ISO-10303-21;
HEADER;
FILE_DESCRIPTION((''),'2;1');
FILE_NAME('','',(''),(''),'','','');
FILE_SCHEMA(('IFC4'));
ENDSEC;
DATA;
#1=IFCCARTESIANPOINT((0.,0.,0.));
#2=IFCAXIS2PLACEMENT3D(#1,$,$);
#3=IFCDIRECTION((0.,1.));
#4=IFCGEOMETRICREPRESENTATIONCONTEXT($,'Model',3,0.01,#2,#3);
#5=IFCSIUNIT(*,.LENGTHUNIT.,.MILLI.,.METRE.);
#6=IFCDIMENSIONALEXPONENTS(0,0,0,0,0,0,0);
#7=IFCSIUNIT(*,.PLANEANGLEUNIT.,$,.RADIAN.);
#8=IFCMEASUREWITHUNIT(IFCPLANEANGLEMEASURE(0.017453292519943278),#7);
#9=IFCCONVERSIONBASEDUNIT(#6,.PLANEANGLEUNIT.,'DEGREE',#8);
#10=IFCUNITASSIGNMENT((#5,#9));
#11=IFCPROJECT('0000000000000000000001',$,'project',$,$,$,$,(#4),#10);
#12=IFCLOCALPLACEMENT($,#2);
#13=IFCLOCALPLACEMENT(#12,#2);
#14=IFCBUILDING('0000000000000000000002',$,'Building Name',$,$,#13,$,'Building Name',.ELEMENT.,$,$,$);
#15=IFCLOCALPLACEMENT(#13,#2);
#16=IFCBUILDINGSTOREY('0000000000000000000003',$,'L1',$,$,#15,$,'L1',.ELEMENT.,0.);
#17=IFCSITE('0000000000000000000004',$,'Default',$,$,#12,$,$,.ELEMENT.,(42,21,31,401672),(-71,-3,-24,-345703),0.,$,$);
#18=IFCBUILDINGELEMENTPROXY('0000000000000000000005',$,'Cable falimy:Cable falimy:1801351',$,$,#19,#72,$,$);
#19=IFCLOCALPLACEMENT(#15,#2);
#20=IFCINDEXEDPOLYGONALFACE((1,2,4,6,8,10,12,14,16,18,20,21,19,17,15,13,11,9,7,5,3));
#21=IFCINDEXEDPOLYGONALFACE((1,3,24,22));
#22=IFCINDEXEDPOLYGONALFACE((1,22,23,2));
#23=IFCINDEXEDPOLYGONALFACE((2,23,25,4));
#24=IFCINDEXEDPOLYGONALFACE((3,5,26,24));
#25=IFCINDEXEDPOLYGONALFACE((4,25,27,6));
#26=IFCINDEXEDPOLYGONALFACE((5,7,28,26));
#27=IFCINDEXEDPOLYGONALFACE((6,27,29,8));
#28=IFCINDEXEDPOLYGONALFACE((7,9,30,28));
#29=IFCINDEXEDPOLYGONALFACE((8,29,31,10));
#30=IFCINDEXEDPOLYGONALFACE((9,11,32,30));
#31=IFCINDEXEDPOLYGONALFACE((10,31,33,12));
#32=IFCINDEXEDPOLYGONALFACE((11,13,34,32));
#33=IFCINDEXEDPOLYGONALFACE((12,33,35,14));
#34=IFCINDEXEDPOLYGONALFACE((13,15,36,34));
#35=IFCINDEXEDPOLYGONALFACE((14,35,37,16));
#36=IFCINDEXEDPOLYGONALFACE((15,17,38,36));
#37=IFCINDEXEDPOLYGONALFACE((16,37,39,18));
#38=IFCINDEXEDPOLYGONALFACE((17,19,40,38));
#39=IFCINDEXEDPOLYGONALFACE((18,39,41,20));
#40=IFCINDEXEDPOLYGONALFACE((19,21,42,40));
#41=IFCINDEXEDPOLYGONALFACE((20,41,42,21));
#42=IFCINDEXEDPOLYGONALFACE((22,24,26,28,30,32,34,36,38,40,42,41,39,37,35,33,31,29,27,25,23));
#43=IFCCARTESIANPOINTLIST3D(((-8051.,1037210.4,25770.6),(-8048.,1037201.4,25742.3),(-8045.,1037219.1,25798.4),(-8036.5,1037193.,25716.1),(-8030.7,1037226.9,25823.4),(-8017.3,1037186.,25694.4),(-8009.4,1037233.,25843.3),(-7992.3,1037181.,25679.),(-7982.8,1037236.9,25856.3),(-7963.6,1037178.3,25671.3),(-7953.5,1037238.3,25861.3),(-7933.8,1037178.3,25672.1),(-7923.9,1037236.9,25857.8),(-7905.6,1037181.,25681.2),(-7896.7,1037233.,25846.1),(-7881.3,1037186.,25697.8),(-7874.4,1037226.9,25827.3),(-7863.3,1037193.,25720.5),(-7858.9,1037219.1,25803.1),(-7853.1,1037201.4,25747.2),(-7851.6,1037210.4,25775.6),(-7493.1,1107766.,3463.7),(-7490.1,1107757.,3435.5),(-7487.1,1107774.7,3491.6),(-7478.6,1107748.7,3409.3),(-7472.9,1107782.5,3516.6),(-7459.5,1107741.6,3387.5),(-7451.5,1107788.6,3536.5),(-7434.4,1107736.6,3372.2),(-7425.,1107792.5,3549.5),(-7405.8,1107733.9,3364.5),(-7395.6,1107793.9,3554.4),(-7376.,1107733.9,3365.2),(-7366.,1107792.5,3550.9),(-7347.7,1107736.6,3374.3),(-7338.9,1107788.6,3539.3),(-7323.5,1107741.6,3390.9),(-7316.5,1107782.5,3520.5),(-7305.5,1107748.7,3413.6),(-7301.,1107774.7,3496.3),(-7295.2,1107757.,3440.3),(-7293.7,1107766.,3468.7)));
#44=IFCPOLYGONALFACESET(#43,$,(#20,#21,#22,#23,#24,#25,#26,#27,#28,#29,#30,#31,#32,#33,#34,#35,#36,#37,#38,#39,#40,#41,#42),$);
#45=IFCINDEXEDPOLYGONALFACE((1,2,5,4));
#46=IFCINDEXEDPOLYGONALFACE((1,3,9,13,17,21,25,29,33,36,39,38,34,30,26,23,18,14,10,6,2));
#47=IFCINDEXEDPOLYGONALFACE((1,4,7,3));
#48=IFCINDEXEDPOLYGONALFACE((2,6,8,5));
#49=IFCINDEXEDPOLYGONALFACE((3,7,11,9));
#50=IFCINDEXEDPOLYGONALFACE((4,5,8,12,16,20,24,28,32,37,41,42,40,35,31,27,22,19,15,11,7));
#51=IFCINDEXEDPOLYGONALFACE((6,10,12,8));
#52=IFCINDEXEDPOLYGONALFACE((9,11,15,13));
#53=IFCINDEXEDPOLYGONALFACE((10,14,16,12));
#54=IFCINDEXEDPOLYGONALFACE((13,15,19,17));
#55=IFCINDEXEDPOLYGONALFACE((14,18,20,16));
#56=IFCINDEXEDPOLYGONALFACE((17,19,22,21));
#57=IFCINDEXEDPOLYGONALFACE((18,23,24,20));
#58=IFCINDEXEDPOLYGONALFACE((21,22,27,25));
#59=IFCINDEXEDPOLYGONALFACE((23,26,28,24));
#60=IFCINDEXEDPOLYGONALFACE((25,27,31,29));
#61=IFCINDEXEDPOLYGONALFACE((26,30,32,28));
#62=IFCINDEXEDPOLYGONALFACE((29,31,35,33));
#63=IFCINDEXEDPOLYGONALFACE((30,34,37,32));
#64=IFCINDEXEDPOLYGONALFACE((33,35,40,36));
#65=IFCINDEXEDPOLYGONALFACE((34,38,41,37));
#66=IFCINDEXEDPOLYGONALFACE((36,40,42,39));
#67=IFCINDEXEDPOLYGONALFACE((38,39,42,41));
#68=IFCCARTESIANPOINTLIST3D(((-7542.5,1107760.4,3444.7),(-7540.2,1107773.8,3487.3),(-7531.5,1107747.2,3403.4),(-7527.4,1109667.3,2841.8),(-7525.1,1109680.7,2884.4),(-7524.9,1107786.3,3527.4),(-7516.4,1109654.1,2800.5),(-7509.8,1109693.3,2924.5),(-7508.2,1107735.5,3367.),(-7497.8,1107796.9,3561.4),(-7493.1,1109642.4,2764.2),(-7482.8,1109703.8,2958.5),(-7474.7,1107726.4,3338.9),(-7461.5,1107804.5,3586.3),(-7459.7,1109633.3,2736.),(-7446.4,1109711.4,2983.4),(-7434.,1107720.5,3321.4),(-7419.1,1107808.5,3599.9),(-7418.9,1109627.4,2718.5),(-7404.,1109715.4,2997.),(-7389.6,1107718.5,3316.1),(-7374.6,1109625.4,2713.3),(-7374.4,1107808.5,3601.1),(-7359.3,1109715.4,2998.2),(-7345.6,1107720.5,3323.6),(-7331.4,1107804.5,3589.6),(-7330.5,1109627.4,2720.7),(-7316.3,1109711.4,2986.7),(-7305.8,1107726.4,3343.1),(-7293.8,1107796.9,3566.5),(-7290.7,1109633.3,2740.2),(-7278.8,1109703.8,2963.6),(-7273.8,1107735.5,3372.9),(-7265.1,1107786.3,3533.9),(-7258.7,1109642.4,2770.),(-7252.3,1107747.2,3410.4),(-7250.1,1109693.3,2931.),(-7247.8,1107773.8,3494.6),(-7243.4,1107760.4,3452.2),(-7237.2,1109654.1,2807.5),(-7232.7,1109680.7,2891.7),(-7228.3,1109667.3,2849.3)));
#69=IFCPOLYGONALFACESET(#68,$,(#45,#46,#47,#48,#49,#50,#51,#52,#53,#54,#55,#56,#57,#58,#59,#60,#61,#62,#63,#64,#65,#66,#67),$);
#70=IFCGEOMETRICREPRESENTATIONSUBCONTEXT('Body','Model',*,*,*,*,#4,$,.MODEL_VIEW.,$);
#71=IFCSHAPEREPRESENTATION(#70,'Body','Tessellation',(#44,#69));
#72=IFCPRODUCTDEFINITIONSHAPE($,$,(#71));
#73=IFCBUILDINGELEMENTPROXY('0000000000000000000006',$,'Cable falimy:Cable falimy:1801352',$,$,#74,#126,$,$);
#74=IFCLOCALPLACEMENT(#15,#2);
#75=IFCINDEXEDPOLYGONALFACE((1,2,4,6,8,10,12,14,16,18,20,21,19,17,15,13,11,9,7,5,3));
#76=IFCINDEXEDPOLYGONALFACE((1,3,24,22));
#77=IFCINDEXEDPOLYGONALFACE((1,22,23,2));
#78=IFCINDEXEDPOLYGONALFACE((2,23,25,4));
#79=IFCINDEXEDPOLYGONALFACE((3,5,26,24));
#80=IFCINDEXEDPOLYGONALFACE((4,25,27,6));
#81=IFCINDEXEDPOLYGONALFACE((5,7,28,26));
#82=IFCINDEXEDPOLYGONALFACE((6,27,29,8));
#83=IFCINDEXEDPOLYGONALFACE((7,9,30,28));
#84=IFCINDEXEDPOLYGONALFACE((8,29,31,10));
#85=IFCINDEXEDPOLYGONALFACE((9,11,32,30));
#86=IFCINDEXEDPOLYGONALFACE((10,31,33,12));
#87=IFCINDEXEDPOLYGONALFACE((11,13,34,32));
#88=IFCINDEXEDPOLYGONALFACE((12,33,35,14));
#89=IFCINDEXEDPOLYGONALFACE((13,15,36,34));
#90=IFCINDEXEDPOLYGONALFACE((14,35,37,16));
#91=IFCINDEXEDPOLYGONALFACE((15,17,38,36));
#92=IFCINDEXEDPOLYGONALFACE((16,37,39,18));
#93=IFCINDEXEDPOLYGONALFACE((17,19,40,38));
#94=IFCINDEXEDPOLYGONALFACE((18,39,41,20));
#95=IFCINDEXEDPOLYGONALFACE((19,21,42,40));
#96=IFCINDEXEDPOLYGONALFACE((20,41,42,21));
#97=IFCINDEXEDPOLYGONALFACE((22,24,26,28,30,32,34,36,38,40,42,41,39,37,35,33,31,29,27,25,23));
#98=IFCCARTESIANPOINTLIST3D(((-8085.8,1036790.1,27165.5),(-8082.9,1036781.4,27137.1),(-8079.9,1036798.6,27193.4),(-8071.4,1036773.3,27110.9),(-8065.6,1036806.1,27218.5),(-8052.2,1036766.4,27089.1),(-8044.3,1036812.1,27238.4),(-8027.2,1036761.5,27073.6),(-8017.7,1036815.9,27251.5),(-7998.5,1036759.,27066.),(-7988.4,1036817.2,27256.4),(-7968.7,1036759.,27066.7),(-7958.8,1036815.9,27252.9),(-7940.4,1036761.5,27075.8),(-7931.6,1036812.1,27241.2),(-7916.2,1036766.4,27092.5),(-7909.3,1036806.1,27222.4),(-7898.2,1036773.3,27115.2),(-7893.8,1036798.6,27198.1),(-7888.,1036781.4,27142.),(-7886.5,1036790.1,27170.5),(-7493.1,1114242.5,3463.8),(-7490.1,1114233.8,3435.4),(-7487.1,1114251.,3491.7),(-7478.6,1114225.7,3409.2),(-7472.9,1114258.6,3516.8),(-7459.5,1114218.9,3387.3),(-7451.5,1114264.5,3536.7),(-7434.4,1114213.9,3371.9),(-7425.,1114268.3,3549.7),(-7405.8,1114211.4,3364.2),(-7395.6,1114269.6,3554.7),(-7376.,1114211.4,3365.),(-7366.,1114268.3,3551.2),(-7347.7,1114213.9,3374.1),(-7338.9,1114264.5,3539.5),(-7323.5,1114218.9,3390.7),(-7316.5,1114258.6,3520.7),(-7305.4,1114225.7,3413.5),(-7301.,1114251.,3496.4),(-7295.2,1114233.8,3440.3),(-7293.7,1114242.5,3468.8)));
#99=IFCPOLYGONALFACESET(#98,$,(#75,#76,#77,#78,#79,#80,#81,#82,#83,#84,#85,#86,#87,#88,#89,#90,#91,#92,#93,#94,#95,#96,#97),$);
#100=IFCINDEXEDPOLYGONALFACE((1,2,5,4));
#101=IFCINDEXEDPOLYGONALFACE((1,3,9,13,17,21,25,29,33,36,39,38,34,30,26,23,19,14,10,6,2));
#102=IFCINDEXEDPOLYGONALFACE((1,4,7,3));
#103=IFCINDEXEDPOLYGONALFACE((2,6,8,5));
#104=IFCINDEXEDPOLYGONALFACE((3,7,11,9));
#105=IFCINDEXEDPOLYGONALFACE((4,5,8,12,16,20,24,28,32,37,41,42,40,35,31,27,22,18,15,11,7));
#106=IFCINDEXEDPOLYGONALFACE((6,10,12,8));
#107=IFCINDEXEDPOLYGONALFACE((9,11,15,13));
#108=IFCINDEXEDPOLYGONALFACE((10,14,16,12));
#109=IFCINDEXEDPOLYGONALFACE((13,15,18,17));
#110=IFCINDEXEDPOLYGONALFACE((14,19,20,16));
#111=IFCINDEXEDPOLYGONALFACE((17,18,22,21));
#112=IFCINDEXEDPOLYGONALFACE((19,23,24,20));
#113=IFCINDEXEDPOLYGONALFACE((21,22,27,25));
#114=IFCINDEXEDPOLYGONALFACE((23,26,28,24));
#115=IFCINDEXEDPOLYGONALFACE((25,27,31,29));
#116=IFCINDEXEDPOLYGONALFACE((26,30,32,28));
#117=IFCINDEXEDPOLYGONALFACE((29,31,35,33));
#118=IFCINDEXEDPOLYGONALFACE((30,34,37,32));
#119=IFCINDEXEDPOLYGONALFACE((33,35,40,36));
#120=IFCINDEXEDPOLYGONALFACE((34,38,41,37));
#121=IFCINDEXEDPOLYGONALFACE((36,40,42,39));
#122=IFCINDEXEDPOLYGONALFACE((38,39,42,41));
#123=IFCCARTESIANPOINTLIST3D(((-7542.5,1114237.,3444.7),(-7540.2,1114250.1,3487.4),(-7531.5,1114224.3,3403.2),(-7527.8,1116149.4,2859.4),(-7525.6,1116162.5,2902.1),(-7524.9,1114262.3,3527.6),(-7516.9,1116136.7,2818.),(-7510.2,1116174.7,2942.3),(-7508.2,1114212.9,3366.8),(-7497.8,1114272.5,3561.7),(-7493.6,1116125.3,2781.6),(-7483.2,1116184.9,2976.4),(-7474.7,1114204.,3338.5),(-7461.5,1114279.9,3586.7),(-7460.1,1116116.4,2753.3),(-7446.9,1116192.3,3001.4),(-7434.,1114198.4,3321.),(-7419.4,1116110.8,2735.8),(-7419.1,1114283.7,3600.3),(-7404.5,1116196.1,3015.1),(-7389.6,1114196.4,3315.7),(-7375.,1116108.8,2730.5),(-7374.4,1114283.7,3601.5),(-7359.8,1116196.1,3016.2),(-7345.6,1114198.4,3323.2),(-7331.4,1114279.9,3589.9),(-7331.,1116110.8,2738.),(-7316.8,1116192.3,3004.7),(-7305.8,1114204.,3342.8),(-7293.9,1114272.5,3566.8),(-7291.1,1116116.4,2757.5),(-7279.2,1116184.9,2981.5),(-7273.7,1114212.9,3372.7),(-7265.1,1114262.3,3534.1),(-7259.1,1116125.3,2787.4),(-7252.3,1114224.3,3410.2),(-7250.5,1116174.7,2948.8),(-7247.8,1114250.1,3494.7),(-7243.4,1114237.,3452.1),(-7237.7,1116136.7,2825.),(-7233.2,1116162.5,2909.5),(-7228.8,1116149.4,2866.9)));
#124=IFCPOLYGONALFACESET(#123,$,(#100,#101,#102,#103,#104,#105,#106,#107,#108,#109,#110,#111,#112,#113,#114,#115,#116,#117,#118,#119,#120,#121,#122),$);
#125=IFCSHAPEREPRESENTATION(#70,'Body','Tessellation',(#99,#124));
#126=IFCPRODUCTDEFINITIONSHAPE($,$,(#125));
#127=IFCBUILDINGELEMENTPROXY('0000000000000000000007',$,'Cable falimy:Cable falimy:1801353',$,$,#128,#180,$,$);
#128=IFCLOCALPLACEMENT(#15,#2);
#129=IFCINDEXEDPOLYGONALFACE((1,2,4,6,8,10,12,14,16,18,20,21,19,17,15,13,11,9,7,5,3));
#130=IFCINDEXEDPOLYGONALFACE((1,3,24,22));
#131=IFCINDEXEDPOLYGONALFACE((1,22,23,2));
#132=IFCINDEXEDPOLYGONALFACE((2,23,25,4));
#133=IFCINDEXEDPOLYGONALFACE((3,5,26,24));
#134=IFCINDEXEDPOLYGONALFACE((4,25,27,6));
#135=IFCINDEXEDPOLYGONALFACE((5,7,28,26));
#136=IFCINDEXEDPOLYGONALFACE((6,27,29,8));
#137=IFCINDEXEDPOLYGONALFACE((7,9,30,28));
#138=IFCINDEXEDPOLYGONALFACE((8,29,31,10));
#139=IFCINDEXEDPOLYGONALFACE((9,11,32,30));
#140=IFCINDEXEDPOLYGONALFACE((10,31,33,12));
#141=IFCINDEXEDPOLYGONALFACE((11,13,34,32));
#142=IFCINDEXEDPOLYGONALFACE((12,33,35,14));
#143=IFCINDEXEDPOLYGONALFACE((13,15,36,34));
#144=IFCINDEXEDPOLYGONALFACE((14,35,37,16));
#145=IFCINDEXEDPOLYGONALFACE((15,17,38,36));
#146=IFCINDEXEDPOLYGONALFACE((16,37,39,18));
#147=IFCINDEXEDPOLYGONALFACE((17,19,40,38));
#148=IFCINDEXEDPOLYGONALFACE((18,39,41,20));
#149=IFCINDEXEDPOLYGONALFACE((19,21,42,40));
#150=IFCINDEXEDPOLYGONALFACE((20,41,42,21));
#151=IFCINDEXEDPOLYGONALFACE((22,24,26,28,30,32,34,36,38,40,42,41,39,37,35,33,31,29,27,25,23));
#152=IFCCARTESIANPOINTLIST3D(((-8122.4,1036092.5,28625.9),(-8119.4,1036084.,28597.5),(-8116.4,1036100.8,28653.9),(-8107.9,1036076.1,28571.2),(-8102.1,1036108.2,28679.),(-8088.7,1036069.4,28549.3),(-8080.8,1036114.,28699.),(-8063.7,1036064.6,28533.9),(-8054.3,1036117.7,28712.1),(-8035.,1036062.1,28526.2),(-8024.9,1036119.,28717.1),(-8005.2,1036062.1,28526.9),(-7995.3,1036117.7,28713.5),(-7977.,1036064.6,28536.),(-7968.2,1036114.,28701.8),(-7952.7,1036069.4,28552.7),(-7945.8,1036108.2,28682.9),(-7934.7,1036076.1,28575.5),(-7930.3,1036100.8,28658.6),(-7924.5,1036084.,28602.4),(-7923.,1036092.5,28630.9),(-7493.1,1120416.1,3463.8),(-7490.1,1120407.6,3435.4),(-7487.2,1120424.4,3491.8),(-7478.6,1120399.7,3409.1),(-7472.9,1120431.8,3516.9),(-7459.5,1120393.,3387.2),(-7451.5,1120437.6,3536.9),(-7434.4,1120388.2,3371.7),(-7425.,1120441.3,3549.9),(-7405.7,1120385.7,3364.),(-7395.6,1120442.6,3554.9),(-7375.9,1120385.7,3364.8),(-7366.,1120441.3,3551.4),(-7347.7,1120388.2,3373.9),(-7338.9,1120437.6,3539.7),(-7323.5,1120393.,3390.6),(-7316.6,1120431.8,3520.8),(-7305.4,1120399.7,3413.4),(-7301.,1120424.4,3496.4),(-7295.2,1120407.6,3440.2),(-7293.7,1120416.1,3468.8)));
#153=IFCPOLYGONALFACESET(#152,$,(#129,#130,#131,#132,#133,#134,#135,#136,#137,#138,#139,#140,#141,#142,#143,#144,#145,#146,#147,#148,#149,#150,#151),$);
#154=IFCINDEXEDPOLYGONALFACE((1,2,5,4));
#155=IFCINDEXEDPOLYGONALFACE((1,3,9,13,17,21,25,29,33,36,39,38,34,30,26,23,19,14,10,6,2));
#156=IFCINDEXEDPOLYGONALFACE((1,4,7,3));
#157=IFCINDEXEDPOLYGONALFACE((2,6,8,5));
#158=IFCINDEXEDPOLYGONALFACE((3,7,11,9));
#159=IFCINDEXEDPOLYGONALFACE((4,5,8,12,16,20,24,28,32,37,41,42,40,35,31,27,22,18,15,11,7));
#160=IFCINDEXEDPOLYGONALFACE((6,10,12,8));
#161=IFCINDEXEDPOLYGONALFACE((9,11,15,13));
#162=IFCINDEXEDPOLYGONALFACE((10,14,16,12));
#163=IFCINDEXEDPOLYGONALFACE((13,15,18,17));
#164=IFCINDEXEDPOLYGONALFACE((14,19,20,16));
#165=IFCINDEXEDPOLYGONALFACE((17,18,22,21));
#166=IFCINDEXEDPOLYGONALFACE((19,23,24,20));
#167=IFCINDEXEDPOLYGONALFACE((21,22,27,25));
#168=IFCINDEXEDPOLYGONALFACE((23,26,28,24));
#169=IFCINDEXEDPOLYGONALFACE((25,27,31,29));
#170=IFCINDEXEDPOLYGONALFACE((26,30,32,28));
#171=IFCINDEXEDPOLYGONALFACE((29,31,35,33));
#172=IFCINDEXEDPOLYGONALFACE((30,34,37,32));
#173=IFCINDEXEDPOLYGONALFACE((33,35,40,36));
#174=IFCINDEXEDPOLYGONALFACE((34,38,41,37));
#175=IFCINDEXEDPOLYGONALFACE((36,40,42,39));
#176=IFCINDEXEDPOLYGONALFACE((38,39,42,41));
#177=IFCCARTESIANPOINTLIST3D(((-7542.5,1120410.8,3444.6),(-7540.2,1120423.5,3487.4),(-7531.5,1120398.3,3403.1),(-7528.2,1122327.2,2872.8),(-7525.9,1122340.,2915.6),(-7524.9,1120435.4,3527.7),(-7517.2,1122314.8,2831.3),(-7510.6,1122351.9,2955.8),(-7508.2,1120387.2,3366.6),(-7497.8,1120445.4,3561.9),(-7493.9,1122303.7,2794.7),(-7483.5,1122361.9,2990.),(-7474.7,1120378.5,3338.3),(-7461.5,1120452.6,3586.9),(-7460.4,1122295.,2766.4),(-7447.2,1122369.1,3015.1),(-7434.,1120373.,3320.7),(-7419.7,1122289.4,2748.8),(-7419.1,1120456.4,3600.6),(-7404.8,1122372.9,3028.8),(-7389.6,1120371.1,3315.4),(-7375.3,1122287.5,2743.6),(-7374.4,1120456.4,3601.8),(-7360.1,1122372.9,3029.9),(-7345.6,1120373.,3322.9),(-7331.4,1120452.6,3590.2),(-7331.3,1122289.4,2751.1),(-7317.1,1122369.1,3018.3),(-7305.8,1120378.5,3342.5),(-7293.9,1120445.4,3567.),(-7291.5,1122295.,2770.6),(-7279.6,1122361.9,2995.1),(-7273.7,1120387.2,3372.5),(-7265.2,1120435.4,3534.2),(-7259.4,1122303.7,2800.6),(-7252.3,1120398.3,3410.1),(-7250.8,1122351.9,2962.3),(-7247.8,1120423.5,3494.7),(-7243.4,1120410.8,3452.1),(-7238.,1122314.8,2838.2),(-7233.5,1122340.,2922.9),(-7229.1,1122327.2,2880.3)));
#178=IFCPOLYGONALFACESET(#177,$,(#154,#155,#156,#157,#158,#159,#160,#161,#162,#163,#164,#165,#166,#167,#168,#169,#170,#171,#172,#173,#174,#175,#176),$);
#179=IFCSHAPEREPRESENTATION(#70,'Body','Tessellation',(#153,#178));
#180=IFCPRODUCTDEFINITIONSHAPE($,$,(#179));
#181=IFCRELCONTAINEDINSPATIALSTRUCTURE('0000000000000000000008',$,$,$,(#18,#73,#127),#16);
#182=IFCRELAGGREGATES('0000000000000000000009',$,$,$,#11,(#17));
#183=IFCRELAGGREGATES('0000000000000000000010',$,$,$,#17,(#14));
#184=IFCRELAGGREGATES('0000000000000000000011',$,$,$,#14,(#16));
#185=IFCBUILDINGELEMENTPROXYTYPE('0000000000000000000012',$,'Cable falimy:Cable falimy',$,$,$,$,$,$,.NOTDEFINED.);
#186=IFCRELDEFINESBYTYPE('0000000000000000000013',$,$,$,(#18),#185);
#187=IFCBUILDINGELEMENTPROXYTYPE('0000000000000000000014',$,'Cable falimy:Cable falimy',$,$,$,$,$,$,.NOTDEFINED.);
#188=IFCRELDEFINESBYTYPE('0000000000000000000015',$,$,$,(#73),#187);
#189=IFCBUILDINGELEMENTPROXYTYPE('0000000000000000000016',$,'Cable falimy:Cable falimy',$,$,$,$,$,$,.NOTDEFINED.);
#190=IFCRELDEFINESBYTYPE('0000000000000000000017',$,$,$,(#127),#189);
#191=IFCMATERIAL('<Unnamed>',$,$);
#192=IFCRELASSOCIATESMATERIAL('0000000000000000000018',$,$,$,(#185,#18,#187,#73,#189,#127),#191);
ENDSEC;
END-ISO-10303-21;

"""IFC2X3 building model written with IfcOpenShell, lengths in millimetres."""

from ifc_helpers import new_model, entity, si_unit, converted_unit, direction, frame, frame_2d, origin, place, context, subcontext, project, spatial, circle, extrude, source, transform, mapped, material, type_object, type_shapes, element, save


model = new_model("IFC2X3")

# Units and contexts
model_context = context("Model", 3, precision=0.01, world=origin(), true_north=direction((0.0, 1.0)))
body_context = subcontext(model_context, "Body", "Model", "MODEL_VIEW")
ifc_project = project(units=[si_unit("LENGTHUNIT", "METRE", prefix="MILLI"), converted_unit("PLANEANGLEUNIT", "DEGREE", entity("IfcPlaneAngleMeasure", 0.017453292519943278), si_unit("PLANEANGLEUNIT", "RADIAN"), dimensions=[0, 0, 0, 0, 0, 0, 0])], contexts=[model_context])

# Site, building, storey
site_placement = place(None, origin())
site = spatial("IfcSite", under=ifc_project, at=site_placement, Name="Default", CompositionType="ELEMENT", RefLatitude=(42, 21, 31, 401672), RefLongitude=(-71, -3, -24, -345703), RefElevation=0.0)
building_placement = place(site_placement, origin())
building = spatial("IfcBuilding", under=site, at=building_placement, Name="Building Name", LongName="Building Name", CompositionType="ELEMENT")
storey_placement = place(building_placement, origin())
storey = spatial("IfcBuildingStorey", under=building, at=storey_placement, Name="L1", LongName="L1", CompositionType="ELEMENT", Elevation=0.0)

# Shared definitions
ifc_material = material(Name="<Unnamed>")

# Building element proxies
building_element_proxy_type_1 = type_object("IfcBuildingElementProxyType", Name="Cable falimy:Cable falimy", PredefinedType="NOTDEFINED", material=ifc_material)
shared_shape_1 = source(origin(), body_context, "Body", "SweptSolid", [
    extrude(circle(Radius=100.0, at=frame_2d((0.0, 0.0), x_axis=(1.0, 0.0))), frame((0.0, 0.0, 0.0), z_axis=(0.953454, 0.0, 0.301538), x_axis=(-0.301538, 0.0, 0.953454)), (0.0, 0.0, 1.0), 74000.0),
    extrude(circle(Radius=150.0, at=frame_2d((0.0, 0.0), x_axis=(1.0, 0.0))), frame((-1906.9, 0.0, -603.1), z_axis=(0.953454, 0.0, 0.301538), x_axis=(0.301538, 0.0, -0.953454)), (0.0, 0.0, 1.0), 2000.0),
])
type_shapes(building_element_proxy_type_1, [shared_shape_1])
proxy_1_placement = place(storey_placement, frame((-7393.2, 1107763.7, 3459.1), z_axis=(-0.025001, 0.0, 0.999687), x_axis=(0.0, -1.0, 0.0)))
element("IfcBuildingElementProxy", 1, at=proxy_1_placement, inside=storey, type_object=building_element_proxy_type_1, material=ifc_material, Name="Cable falimy:Cable falimy:1801351", context=body_context, shape_type="MappedRepresentation", body=[
    mapped(shared_shape_1, transform((0.0, 0.0, 0.0), scale=1.0)),
])
building_element_proxy_type_2 = type_object("IfcBuildingElementProxyType", Name="Cable falimy:Cable falimy", PredefinedType="NOTDEFINED", material=ifc_material)
shared_shape_2 = source(origin(), body_context, "Body", "SweptSolid", [
    extrude(circle(Radius=100.0, at=frame_2d((0.0, 0.0), x_axis=(1.0, 0.0))), frame((0.0, 0.0, 0.0), z_axis=(0.956203, 0.0, 0.292706), x_axis=(-0.292706, 0.0, 0.956203)), (0.0, 0.0, 1.0), 81000.0),
    extrude(circle(Radius=150.0, at=frame_2d((0.0, 0.0), x_axis=(1.0, 0.0))), frame((-1912.4, 0.0, -585.4), z_axis=(0.956203, 0.0, 0.292706), x_axis=(0.292706, 0.0, -0.956203)), (0.0, 0.0, 1.0), 2000.0),
])
type_shapes(building_element_proxy_type_2, [shared_shape_2])
proxy_2_placement = place(storey_placement, frame((-7393.2, 1114240.3, 3459.1), z_axis=(-0.025001, 0.0, 0.999687), x_axis=(0.0, -1.0, 0.0)))
element("IfcBuildingElementProxy", 2, at=proxy_2_placement, inside=storey, type_object=building_element_proxy_type_2, material=ifc_material, Name="Cable falimy:Cable falimy:1801352", context=body_context, shape_type="MappedRepresentation", body=[
    mapped(shared_shape_2, transform((0.0, 0.0, 0.0), scale=1.0)),
])
building_element_proxy_type_3 = type_object("IfcBuildingElementProxyType", Name="Cable falimy:Cable falimy", PredefinedType="NOTDEFINED", material=ifc_material)
shared_shape_3 = source(origin(), body_context, "Body", "SweptSolid", [
    extrude(circle(Radius=100.0, at=frame_2d((0.0, 0.0), x_axis=(1.0, 0.0))), frame((0.0, 0.0, 0.0), z_axis=(0.958223, 0.0, 0.286023), x_axis=(-0.286023, 0.0, 0.958223)), (0.0, 0.0, 1.0), 88000.0),
    extrude(circle(Radius=150.0, at=frame_2d((0.0, 0.0), x_axis=(1.0, 0.0))), frame((-1916.4, 0.0, -572.0), z_axis=(0.958223, 0.0, 0.286023), x_axis=(0.286023, 0.0, -0.958223)), (0.0, 0.0, 1.0), 2000.0),
])
type_shapes(building_element_proxy_type_3, [shared_shape_3])
proxy_3_placement = place(storey_placement, frame((-7393.2, 1120414.0, 3459.1), z_axis=(-0.025001, 0.0, 0.999687), x_axis=(0.0, -1.0, 0.0)))
element("IfcBuildingElementProxy", 3, at=proxy_3_placement, inside=storey, type_object=building_element_proxy_type_3, material=ifc_material, Name="Cable falimy:Cable falimy:1801353", context=body_context, shape_type="MappedRepresentation", body=[
    mapped(shared_shape_3, transform((0.0, 0.0, 0.0), scale=1.0)),
])

save(model, "model.ifc")
